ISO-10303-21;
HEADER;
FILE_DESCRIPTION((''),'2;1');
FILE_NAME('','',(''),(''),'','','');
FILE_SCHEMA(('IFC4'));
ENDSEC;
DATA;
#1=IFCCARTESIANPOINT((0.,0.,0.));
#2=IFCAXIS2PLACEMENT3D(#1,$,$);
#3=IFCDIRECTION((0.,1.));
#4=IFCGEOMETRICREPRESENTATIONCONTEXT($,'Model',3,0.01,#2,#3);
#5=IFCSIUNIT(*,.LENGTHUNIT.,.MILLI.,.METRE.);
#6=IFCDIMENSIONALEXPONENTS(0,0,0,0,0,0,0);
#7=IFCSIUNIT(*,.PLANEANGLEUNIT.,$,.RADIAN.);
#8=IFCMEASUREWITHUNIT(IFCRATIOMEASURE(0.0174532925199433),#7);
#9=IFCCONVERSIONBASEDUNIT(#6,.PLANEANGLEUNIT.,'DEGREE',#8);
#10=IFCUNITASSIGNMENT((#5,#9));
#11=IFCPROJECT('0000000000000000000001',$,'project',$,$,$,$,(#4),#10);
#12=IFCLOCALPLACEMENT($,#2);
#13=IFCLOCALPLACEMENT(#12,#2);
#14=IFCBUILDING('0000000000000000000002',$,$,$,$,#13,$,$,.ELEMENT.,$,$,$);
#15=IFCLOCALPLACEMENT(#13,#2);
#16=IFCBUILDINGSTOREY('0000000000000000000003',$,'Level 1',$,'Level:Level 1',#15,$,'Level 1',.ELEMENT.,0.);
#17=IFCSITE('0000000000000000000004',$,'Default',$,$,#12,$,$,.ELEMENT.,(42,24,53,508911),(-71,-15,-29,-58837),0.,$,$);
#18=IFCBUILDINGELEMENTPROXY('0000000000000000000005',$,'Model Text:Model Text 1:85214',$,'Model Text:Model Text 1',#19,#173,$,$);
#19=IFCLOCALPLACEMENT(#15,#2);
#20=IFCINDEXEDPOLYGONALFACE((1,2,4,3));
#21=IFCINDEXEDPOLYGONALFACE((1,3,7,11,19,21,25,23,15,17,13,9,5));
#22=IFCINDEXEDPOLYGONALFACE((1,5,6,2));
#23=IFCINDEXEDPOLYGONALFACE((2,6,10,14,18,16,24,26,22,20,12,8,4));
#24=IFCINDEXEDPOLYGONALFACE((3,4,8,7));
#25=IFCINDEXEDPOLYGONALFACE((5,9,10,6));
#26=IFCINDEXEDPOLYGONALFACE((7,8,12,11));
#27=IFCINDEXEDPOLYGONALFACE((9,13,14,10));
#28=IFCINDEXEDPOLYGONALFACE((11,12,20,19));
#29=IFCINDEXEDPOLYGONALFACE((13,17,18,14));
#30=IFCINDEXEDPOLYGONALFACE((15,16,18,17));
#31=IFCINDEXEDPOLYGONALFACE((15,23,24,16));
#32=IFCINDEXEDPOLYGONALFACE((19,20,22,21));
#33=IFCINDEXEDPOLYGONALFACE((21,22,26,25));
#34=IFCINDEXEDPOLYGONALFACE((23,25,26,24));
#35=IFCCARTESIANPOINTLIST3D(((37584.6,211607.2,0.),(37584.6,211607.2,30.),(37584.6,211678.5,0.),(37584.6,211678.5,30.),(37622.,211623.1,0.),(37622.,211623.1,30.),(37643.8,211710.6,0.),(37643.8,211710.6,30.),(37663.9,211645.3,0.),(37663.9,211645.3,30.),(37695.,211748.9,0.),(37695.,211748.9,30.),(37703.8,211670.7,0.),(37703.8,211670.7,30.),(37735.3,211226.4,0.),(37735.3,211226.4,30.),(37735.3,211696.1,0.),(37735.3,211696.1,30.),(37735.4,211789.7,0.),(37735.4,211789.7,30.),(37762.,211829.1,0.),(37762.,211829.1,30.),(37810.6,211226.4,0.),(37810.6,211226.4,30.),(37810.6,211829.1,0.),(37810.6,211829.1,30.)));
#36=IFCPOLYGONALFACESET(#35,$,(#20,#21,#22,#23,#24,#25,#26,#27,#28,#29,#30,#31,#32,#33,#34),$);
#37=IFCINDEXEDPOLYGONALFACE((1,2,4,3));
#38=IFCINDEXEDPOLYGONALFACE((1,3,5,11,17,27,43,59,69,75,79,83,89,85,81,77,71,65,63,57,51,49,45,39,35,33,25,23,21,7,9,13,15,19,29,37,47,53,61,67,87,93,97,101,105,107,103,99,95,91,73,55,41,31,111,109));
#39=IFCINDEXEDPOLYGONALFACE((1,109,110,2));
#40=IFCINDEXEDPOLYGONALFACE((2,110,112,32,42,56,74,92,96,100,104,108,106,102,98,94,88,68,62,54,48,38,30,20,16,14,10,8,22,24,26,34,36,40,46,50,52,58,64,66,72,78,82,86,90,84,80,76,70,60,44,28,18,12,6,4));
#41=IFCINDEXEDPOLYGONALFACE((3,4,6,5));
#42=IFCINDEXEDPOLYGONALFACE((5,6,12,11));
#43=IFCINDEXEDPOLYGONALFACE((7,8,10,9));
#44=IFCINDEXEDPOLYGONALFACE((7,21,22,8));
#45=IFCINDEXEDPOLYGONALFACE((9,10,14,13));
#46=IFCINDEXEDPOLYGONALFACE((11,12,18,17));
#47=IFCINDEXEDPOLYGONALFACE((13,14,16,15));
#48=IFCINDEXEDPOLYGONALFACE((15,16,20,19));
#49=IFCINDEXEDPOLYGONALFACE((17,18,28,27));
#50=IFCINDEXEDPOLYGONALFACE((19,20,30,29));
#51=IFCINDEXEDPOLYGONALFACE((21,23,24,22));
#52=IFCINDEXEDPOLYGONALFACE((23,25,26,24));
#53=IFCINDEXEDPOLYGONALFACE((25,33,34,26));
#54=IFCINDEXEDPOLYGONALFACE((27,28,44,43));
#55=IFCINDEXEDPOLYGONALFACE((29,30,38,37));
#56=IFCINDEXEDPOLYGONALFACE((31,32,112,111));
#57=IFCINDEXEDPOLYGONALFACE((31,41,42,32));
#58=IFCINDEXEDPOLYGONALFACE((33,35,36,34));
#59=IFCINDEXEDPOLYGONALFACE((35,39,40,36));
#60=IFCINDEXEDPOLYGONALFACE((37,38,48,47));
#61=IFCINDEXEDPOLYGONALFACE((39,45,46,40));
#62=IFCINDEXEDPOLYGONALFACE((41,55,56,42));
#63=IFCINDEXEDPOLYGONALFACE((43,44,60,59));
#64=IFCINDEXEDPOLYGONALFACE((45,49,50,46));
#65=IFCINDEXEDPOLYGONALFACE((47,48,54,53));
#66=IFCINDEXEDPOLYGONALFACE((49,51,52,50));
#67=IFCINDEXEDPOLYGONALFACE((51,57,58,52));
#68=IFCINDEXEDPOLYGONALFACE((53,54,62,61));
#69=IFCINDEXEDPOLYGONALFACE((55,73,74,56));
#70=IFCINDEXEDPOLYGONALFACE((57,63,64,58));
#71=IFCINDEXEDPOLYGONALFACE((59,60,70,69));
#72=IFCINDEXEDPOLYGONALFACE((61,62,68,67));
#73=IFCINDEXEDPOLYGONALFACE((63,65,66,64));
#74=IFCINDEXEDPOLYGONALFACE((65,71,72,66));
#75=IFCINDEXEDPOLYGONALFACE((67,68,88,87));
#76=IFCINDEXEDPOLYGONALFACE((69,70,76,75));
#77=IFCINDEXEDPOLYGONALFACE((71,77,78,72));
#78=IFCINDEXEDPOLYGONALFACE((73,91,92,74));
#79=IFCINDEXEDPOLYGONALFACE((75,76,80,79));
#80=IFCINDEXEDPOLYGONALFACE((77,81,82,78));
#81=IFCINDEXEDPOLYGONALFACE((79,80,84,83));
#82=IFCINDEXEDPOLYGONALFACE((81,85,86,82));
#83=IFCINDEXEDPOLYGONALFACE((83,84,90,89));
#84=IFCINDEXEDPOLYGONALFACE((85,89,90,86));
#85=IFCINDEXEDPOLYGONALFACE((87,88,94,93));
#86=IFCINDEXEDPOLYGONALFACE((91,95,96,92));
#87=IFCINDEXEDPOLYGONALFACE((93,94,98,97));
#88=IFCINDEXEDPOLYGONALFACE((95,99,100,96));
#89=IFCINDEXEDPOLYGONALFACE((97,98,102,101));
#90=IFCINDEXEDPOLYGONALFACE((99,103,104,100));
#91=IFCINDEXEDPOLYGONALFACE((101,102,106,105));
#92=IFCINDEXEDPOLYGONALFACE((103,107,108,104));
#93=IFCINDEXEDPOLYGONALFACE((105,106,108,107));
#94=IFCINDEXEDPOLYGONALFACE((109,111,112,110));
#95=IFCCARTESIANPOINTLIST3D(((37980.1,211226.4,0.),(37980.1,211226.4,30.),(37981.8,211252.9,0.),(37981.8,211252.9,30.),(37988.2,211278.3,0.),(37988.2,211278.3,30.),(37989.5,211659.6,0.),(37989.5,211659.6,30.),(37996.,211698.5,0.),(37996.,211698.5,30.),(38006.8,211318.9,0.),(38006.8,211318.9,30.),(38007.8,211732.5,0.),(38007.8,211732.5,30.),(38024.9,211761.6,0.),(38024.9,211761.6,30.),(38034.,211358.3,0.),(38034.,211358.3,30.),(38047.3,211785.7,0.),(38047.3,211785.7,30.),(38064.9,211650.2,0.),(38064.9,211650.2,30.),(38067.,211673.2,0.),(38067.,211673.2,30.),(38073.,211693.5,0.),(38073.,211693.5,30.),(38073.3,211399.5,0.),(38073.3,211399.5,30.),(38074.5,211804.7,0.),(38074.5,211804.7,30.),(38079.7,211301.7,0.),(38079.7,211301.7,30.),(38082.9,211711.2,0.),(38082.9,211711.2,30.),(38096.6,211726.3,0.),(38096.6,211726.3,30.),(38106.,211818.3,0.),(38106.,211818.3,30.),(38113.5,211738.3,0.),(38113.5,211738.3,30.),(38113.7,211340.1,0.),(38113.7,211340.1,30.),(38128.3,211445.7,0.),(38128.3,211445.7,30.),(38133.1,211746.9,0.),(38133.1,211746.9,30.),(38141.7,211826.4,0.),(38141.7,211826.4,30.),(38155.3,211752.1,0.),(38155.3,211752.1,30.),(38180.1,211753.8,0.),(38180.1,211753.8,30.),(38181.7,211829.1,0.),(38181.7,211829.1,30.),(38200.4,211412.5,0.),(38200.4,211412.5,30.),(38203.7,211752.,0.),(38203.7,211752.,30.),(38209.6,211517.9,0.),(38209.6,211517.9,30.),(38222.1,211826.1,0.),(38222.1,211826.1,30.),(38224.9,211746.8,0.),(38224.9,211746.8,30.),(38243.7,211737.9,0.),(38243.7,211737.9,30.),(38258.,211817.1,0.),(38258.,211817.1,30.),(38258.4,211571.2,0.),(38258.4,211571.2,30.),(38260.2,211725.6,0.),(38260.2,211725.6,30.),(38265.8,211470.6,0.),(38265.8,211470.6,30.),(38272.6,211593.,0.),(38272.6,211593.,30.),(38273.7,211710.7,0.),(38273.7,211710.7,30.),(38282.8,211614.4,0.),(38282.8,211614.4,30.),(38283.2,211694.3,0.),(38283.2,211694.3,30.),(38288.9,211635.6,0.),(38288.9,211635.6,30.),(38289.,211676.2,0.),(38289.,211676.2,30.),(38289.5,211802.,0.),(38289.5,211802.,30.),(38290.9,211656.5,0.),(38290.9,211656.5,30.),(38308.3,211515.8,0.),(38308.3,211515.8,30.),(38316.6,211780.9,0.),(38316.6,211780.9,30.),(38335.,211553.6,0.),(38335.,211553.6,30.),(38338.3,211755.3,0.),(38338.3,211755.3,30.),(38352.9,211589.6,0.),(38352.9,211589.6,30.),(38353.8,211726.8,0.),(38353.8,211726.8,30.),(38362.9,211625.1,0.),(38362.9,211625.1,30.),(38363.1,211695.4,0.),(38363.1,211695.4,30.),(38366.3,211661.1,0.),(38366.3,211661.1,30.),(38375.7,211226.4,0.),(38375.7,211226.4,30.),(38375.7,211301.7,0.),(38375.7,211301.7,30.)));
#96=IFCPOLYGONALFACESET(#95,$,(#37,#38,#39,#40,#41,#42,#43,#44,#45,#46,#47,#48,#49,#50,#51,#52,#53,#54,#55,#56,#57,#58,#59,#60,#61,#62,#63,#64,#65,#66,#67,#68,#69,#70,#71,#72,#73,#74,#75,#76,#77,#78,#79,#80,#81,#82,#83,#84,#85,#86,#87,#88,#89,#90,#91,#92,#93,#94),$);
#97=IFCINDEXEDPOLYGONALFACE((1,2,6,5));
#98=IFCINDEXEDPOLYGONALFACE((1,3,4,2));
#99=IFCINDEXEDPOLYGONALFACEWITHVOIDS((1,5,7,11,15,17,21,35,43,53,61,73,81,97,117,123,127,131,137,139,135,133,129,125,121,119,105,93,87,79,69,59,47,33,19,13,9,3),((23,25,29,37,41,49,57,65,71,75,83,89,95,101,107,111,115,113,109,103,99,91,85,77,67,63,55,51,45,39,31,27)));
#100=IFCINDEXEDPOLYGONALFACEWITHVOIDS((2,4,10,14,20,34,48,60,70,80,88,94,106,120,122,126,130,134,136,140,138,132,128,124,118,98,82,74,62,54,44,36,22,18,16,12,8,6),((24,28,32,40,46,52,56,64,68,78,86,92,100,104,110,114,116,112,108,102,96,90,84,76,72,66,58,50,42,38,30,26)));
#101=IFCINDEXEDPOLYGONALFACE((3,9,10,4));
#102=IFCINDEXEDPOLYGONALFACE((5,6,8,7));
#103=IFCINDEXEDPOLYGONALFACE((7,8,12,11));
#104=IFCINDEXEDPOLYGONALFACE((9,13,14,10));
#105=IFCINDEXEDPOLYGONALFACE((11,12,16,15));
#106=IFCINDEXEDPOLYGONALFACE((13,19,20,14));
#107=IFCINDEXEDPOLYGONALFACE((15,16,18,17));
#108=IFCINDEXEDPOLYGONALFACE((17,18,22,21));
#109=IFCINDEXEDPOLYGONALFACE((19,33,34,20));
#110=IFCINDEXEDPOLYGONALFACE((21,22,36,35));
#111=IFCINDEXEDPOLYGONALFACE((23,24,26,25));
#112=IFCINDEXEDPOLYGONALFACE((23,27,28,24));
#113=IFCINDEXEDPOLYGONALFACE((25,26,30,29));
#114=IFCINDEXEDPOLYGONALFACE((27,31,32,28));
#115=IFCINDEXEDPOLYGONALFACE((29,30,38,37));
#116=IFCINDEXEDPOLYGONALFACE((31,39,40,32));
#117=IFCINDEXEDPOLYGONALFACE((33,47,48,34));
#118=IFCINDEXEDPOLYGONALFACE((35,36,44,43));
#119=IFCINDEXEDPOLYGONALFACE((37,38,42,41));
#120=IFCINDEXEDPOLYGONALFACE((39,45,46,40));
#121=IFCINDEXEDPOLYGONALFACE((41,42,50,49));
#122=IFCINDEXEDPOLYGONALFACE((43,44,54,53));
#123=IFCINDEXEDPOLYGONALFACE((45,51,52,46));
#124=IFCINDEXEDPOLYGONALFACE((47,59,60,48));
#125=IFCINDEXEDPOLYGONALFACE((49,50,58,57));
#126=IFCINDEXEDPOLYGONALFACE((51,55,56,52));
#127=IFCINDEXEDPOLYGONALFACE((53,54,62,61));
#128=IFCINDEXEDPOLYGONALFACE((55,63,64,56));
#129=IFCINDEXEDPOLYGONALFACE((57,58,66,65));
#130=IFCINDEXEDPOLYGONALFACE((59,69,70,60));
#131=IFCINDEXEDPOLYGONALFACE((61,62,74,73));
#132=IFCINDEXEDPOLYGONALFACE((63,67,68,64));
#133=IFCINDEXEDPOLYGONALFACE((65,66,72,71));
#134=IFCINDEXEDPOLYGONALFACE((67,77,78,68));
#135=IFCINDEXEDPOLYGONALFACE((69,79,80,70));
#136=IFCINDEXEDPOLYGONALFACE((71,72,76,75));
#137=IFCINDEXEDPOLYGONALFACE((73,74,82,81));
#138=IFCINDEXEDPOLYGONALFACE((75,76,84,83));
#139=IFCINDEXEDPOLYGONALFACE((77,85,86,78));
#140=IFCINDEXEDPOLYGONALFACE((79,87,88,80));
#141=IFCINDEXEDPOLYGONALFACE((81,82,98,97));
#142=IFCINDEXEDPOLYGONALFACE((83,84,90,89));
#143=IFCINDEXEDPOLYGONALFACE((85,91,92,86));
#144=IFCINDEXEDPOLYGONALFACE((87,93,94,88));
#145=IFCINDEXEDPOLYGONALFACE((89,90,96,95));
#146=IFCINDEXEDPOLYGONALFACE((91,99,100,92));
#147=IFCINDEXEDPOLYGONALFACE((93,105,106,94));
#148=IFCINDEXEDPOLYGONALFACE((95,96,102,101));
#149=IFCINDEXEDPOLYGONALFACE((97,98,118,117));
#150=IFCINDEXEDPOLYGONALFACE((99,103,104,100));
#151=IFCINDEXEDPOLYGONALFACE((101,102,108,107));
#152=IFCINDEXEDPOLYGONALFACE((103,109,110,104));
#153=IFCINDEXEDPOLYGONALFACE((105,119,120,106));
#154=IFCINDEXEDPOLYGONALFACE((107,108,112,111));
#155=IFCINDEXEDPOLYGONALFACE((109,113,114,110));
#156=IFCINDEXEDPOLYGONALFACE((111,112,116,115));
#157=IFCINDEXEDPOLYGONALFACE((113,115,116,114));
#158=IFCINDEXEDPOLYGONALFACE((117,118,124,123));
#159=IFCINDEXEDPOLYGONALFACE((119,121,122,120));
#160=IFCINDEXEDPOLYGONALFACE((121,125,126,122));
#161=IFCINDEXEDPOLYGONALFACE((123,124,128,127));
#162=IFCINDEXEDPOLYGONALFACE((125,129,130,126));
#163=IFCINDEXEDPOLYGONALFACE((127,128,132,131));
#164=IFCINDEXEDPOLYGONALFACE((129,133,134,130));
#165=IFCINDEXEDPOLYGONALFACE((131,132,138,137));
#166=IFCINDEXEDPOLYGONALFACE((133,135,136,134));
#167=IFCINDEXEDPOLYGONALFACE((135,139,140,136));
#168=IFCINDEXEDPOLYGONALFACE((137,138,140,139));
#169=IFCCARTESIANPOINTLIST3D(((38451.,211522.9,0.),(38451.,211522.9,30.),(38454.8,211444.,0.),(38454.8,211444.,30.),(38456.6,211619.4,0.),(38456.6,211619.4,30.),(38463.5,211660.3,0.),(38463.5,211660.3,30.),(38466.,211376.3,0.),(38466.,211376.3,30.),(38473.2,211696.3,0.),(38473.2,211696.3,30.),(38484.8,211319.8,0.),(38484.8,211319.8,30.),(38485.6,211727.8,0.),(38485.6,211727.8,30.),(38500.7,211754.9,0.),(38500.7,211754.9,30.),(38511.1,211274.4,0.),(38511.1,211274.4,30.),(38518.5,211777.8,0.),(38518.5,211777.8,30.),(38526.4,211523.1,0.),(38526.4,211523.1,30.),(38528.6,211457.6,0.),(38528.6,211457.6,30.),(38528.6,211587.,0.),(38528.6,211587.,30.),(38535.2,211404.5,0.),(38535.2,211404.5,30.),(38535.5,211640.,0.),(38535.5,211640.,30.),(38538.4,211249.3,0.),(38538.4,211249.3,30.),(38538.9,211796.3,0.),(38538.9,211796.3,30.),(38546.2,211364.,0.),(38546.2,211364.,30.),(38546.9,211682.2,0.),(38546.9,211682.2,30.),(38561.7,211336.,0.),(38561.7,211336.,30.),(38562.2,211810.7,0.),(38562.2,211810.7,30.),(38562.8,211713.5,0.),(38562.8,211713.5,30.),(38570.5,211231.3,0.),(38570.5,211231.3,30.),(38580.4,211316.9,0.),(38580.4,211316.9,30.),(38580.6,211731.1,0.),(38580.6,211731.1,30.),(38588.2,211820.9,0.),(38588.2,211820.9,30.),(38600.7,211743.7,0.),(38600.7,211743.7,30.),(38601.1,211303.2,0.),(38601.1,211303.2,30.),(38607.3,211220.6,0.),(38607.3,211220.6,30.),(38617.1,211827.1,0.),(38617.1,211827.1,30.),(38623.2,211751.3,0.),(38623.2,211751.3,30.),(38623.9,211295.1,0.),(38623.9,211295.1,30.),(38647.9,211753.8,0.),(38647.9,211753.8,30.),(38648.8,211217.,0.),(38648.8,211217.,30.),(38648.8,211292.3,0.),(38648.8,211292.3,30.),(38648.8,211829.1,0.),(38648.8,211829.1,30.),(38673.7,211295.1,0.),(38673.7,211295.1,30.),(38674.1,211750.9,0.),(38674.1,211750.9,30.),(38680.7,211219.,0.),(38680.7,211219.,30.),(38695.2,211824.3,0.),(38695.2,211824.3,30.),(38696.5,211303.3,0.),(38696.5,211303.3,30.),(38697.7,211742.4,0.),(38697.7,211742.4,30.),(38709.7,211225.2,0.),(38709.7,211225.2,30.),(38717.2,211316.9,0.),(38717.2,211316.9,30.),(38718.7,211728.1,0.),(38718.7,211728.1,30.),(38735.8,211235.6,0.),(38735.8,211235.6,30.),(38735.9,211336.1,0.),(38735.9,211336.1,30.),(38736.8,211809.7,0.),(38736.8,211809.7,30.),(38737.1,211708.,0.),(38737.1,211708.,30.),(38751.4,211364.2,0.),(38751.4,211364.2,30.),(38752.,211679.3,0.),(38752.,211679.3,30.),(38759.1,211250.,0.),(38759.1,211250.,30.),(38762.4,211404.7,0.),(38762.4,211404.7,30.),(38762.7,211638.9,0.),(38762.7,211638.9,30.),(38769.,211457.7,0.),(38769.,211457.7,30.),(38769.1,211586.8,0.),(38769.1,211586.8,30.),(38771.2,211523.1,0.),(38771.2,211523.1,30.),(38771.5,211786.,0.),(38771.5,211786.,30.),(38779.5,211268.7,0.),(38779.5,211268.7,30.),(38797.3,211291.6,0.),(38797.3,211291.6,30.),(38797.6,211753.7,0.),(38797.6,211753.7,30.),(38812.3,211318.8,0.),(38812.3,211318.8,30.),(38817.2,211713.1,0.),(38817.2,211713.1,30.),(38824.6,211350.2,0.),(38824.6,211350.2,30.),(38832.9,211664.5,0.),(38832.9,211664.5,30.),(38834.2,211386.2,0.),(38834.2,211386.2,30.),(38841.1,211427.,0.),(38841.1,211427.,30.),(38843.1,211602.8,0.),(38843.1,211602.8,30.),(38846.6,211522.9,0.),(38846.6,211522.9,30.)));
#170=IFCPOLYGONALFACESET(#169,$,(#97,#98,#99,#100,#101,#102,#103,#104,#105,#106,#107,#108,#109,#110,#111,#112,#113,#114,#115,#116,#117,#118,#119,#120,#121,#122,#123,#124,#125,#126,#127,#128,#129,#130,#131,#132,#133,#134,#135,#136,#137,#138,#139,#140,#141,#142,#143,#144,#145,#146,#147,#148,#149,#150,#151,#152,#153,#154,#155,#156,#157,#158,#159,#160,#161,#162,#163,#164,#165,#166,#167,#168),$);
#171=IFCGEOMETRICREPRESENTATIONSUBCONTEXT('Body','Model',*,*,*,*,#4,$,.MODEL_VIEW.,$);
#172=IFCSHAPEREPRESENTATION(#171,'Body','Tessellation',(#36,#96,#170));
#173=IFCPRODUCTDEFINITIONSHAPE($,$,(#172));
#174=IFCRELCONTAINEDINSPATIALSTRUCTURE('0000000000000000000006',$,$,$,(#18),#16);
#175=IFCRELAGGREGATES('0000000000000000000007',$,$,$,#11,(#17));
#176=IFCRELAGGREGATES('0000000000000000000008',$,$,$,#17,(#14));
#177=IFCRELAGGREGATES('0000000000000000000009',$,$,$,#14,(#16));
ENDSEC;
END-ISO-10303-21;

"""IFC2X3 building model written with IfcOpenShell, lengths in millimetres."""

from ifc_helpers import new_model, entity, si_unit, converted_unit, direction, frame, origin, place, context, subcontext, project, spatial, polyline, outline, extrude, element, save


model = new_model("IFC2X3")

# Units and contexts
model_context = context("Model", 3, precision=0.01, world=origin(), true_north=direction((0.0, 1.0)))
body_context = subcontext(model_context, "Body", "Model", "MODEL_VIEW")
ifc_project = project(units=[si_unit("LENGTHUNIT", "METRE", prefix="MILLI"), converted_unit("PLANEANGLEUNIT", "DEGREE", entity("IfcRatioMeasure", 0.0174532925199433), si_unit("PLANEANGLEUNIT", "RADIAN"), dimensions=[0, 0, 0, 0, 0, 0, 0])], contexts=[model_context])

# Site, building, storey
site_placement = place(None, origin())
site = spatial("IfcSite", under=ifc_project, at=site_placement, Name="Default", CompositionType="ELEMENT", RefLatitude=(42, 24, 53, 508911), RefLongitude=(-71, -15, -29, -58837), RefElevation=0.0)
building_placement = place(site_placement, origin())
building = spatial("IfcBuilding", under=site, at=building_placement, CompositionType="ELEMENT")
storey_placement = place(building_placement, origin())
storey = spatial("IfcBuildingStorey", under=building, at=storey_placement, Name="Level 1", ObjectType="Level:Level 1", LongName="Level 1", CompositionType="ELEMENT", Elevation=0.0)

# Building element proxy
proxy_1_placement = place(storey_placement, origin())
element("IfcBuildingElementProxy", 1, at=proxy_1_placement, inside=storey, Name="Model Text:Model Text 1:85214", ObjectType="Model Text:Model Text 1", context=body_context, shape_type="SweptSolid", body=[
    extrude(outline(polyline([(-410.6, -111.6), (192.1, -111.6), (192.1, -63.1), (152.7, -36.4), (111.9, 4.0), (73.6, 55.2), (41.4, 114.4), (-29.8, 114.4), (-13.9, 77.0), (8.3, 35.1), (33.7, -4.8), (59.1, -36.3), (-410.6, -36.3), (-410.6, -111.6)])), frame((37699.0, 211637.0, 0.0), z_axis=(0.0, 0.0, 1.0), x_axis=(0.0, 1.0, 0.0)), (0.0, 0.0, 1.0), 30.0),
    extrude(outline(polyline([(-190.2, -317.5), (-190.2, -392.8), (205.4, -392.8), (203.7, -366.3), (197.3, -340.9), (178.7, -300.3), (151.5, -260.9), (112.2, -219.7), (57.2, -173.6), (-24.1, -101.3), (-72.9, -48.0), (-87.1, -26.3), (-97.3, -4.8), (-103.4, 16.4), (-105.4, 37.3), (-103.5, 57.0), (-97.7, 75.0), (-88.2, 91.5), (-74.7, 106.4), (-58.2, 118.7), (-39.4, 127.5), (-18.2, 132.8), (5.4, 134.6), (30.2, 132.9), (52.4, 127.7), (72.0, 119.1), (88.9, 107.1), (102.6, 92.0), (112.5, 74.3), (118.5, 54.0), (120.6, 31.0), (196.0, 40.4), (189.5, 79.3), (177.7, 113.3), (160.6, 142.4), (138.2, 166.5), (111.0, 185.5), (79.5, 199.1), (43.8, 207.2), (3.8, 209.9), (-36.6, 206.9), (-72.5, 197.9), (-104.0, 182.8), (-131.1, 161.7), (-152.8, 136.1), (-168.3, 107.6), (-177.6, 76.2), (-180.8, 41.9), (-177.4, 5.8), (-167.4, -29.6), (-149.5, -65.6), (-122.8, -103.4), (-80.3, -148.6), (-14.9, -206.7), (71.8, -279.1), (105.8, -317.5), (-190.2, -317.5)])), frame((38185.5, 211619.2, 0.0), z_axis=(0.0, 0.0, -1.0), x_axis=(-1.0, 0.0, 0.0)), (0.0, 0.0, -1.0), 30.0),
    extrude(outline(polyline([(-10.6, -198.7), (68.3, -198.7), (136.5, -190.7), (193.9, -174.7), (240.5, -150.6), (266.9, -124.4), (286.3, -93.2), (298.8, -57.0), (304.3, -15.7), (303.8, 16.2), (299.0, 45.5), (289.9, 72.1), (276.6, 96.0), (258.9, 117.3), (236.9, 136.2), (210.4, 152.5), (179.6, 166.3), (144.1, 177.6), (103.7, 186.3), (8.2, 196.4), (-71.8, 196.7), (-134.0, 189.4), (-183.3, 176.1), (-224.7, 158.4), (-258.2, 133.9), (-283.5, 100.3), (-300.1, 59.5), (-307.1, 13.4), (-306.6, -18.4), (-301.8, -47.5), (-292.8, -74.0), (-279.6, -97.9), (-262.0, -119.2), (-240.0, -138.1), (-213.6, -154.5), (-182.8, -168.4), (-147.3, -179.8), (-106.7, -188.6), (-10.6, -198.7)]), holes=[polyline([(-7.2, -123.5), (-71.0, -118.2), (-123.6, -108.8), (-165.2, -95.4), (-195.7, -78.0), (-212.4, -59.4), (-224.1, -38.7), (-230.6, -15.9), (-231.9, 8.9), (-227.8, 35.0), (-218.1, 58.1), (-202.8, 78.4), (-182.0, 95.8), (-152.6, 109.4), (-111.7, 118.1), (-59.4, 122.0), (4.4, 121.1), (69.6, 115.8), (122.2, 106.7), (162.2, 93.7), (189.5, 77.0), (207.7, 57.4), (220.4, 36.0), (227.5, 12.8), (229.1, -12.1), (225.2, -36.8), (215.9, -59.2), (201.3, -79.3), (181.4, -97.1), (152.6, -111.2), (111.6, -120.3), (58.3, -124.4), (-7.2, -123.5)])]), frame((38650.0, 211521.7, 0.0), z_axis=(0.0, 0.0, 1.0), x_axis=(0.047515, -0.998871, 0.0)), (0.0, 0.0, 1.0), 30.0),
])

save(model, "model.ifc")
